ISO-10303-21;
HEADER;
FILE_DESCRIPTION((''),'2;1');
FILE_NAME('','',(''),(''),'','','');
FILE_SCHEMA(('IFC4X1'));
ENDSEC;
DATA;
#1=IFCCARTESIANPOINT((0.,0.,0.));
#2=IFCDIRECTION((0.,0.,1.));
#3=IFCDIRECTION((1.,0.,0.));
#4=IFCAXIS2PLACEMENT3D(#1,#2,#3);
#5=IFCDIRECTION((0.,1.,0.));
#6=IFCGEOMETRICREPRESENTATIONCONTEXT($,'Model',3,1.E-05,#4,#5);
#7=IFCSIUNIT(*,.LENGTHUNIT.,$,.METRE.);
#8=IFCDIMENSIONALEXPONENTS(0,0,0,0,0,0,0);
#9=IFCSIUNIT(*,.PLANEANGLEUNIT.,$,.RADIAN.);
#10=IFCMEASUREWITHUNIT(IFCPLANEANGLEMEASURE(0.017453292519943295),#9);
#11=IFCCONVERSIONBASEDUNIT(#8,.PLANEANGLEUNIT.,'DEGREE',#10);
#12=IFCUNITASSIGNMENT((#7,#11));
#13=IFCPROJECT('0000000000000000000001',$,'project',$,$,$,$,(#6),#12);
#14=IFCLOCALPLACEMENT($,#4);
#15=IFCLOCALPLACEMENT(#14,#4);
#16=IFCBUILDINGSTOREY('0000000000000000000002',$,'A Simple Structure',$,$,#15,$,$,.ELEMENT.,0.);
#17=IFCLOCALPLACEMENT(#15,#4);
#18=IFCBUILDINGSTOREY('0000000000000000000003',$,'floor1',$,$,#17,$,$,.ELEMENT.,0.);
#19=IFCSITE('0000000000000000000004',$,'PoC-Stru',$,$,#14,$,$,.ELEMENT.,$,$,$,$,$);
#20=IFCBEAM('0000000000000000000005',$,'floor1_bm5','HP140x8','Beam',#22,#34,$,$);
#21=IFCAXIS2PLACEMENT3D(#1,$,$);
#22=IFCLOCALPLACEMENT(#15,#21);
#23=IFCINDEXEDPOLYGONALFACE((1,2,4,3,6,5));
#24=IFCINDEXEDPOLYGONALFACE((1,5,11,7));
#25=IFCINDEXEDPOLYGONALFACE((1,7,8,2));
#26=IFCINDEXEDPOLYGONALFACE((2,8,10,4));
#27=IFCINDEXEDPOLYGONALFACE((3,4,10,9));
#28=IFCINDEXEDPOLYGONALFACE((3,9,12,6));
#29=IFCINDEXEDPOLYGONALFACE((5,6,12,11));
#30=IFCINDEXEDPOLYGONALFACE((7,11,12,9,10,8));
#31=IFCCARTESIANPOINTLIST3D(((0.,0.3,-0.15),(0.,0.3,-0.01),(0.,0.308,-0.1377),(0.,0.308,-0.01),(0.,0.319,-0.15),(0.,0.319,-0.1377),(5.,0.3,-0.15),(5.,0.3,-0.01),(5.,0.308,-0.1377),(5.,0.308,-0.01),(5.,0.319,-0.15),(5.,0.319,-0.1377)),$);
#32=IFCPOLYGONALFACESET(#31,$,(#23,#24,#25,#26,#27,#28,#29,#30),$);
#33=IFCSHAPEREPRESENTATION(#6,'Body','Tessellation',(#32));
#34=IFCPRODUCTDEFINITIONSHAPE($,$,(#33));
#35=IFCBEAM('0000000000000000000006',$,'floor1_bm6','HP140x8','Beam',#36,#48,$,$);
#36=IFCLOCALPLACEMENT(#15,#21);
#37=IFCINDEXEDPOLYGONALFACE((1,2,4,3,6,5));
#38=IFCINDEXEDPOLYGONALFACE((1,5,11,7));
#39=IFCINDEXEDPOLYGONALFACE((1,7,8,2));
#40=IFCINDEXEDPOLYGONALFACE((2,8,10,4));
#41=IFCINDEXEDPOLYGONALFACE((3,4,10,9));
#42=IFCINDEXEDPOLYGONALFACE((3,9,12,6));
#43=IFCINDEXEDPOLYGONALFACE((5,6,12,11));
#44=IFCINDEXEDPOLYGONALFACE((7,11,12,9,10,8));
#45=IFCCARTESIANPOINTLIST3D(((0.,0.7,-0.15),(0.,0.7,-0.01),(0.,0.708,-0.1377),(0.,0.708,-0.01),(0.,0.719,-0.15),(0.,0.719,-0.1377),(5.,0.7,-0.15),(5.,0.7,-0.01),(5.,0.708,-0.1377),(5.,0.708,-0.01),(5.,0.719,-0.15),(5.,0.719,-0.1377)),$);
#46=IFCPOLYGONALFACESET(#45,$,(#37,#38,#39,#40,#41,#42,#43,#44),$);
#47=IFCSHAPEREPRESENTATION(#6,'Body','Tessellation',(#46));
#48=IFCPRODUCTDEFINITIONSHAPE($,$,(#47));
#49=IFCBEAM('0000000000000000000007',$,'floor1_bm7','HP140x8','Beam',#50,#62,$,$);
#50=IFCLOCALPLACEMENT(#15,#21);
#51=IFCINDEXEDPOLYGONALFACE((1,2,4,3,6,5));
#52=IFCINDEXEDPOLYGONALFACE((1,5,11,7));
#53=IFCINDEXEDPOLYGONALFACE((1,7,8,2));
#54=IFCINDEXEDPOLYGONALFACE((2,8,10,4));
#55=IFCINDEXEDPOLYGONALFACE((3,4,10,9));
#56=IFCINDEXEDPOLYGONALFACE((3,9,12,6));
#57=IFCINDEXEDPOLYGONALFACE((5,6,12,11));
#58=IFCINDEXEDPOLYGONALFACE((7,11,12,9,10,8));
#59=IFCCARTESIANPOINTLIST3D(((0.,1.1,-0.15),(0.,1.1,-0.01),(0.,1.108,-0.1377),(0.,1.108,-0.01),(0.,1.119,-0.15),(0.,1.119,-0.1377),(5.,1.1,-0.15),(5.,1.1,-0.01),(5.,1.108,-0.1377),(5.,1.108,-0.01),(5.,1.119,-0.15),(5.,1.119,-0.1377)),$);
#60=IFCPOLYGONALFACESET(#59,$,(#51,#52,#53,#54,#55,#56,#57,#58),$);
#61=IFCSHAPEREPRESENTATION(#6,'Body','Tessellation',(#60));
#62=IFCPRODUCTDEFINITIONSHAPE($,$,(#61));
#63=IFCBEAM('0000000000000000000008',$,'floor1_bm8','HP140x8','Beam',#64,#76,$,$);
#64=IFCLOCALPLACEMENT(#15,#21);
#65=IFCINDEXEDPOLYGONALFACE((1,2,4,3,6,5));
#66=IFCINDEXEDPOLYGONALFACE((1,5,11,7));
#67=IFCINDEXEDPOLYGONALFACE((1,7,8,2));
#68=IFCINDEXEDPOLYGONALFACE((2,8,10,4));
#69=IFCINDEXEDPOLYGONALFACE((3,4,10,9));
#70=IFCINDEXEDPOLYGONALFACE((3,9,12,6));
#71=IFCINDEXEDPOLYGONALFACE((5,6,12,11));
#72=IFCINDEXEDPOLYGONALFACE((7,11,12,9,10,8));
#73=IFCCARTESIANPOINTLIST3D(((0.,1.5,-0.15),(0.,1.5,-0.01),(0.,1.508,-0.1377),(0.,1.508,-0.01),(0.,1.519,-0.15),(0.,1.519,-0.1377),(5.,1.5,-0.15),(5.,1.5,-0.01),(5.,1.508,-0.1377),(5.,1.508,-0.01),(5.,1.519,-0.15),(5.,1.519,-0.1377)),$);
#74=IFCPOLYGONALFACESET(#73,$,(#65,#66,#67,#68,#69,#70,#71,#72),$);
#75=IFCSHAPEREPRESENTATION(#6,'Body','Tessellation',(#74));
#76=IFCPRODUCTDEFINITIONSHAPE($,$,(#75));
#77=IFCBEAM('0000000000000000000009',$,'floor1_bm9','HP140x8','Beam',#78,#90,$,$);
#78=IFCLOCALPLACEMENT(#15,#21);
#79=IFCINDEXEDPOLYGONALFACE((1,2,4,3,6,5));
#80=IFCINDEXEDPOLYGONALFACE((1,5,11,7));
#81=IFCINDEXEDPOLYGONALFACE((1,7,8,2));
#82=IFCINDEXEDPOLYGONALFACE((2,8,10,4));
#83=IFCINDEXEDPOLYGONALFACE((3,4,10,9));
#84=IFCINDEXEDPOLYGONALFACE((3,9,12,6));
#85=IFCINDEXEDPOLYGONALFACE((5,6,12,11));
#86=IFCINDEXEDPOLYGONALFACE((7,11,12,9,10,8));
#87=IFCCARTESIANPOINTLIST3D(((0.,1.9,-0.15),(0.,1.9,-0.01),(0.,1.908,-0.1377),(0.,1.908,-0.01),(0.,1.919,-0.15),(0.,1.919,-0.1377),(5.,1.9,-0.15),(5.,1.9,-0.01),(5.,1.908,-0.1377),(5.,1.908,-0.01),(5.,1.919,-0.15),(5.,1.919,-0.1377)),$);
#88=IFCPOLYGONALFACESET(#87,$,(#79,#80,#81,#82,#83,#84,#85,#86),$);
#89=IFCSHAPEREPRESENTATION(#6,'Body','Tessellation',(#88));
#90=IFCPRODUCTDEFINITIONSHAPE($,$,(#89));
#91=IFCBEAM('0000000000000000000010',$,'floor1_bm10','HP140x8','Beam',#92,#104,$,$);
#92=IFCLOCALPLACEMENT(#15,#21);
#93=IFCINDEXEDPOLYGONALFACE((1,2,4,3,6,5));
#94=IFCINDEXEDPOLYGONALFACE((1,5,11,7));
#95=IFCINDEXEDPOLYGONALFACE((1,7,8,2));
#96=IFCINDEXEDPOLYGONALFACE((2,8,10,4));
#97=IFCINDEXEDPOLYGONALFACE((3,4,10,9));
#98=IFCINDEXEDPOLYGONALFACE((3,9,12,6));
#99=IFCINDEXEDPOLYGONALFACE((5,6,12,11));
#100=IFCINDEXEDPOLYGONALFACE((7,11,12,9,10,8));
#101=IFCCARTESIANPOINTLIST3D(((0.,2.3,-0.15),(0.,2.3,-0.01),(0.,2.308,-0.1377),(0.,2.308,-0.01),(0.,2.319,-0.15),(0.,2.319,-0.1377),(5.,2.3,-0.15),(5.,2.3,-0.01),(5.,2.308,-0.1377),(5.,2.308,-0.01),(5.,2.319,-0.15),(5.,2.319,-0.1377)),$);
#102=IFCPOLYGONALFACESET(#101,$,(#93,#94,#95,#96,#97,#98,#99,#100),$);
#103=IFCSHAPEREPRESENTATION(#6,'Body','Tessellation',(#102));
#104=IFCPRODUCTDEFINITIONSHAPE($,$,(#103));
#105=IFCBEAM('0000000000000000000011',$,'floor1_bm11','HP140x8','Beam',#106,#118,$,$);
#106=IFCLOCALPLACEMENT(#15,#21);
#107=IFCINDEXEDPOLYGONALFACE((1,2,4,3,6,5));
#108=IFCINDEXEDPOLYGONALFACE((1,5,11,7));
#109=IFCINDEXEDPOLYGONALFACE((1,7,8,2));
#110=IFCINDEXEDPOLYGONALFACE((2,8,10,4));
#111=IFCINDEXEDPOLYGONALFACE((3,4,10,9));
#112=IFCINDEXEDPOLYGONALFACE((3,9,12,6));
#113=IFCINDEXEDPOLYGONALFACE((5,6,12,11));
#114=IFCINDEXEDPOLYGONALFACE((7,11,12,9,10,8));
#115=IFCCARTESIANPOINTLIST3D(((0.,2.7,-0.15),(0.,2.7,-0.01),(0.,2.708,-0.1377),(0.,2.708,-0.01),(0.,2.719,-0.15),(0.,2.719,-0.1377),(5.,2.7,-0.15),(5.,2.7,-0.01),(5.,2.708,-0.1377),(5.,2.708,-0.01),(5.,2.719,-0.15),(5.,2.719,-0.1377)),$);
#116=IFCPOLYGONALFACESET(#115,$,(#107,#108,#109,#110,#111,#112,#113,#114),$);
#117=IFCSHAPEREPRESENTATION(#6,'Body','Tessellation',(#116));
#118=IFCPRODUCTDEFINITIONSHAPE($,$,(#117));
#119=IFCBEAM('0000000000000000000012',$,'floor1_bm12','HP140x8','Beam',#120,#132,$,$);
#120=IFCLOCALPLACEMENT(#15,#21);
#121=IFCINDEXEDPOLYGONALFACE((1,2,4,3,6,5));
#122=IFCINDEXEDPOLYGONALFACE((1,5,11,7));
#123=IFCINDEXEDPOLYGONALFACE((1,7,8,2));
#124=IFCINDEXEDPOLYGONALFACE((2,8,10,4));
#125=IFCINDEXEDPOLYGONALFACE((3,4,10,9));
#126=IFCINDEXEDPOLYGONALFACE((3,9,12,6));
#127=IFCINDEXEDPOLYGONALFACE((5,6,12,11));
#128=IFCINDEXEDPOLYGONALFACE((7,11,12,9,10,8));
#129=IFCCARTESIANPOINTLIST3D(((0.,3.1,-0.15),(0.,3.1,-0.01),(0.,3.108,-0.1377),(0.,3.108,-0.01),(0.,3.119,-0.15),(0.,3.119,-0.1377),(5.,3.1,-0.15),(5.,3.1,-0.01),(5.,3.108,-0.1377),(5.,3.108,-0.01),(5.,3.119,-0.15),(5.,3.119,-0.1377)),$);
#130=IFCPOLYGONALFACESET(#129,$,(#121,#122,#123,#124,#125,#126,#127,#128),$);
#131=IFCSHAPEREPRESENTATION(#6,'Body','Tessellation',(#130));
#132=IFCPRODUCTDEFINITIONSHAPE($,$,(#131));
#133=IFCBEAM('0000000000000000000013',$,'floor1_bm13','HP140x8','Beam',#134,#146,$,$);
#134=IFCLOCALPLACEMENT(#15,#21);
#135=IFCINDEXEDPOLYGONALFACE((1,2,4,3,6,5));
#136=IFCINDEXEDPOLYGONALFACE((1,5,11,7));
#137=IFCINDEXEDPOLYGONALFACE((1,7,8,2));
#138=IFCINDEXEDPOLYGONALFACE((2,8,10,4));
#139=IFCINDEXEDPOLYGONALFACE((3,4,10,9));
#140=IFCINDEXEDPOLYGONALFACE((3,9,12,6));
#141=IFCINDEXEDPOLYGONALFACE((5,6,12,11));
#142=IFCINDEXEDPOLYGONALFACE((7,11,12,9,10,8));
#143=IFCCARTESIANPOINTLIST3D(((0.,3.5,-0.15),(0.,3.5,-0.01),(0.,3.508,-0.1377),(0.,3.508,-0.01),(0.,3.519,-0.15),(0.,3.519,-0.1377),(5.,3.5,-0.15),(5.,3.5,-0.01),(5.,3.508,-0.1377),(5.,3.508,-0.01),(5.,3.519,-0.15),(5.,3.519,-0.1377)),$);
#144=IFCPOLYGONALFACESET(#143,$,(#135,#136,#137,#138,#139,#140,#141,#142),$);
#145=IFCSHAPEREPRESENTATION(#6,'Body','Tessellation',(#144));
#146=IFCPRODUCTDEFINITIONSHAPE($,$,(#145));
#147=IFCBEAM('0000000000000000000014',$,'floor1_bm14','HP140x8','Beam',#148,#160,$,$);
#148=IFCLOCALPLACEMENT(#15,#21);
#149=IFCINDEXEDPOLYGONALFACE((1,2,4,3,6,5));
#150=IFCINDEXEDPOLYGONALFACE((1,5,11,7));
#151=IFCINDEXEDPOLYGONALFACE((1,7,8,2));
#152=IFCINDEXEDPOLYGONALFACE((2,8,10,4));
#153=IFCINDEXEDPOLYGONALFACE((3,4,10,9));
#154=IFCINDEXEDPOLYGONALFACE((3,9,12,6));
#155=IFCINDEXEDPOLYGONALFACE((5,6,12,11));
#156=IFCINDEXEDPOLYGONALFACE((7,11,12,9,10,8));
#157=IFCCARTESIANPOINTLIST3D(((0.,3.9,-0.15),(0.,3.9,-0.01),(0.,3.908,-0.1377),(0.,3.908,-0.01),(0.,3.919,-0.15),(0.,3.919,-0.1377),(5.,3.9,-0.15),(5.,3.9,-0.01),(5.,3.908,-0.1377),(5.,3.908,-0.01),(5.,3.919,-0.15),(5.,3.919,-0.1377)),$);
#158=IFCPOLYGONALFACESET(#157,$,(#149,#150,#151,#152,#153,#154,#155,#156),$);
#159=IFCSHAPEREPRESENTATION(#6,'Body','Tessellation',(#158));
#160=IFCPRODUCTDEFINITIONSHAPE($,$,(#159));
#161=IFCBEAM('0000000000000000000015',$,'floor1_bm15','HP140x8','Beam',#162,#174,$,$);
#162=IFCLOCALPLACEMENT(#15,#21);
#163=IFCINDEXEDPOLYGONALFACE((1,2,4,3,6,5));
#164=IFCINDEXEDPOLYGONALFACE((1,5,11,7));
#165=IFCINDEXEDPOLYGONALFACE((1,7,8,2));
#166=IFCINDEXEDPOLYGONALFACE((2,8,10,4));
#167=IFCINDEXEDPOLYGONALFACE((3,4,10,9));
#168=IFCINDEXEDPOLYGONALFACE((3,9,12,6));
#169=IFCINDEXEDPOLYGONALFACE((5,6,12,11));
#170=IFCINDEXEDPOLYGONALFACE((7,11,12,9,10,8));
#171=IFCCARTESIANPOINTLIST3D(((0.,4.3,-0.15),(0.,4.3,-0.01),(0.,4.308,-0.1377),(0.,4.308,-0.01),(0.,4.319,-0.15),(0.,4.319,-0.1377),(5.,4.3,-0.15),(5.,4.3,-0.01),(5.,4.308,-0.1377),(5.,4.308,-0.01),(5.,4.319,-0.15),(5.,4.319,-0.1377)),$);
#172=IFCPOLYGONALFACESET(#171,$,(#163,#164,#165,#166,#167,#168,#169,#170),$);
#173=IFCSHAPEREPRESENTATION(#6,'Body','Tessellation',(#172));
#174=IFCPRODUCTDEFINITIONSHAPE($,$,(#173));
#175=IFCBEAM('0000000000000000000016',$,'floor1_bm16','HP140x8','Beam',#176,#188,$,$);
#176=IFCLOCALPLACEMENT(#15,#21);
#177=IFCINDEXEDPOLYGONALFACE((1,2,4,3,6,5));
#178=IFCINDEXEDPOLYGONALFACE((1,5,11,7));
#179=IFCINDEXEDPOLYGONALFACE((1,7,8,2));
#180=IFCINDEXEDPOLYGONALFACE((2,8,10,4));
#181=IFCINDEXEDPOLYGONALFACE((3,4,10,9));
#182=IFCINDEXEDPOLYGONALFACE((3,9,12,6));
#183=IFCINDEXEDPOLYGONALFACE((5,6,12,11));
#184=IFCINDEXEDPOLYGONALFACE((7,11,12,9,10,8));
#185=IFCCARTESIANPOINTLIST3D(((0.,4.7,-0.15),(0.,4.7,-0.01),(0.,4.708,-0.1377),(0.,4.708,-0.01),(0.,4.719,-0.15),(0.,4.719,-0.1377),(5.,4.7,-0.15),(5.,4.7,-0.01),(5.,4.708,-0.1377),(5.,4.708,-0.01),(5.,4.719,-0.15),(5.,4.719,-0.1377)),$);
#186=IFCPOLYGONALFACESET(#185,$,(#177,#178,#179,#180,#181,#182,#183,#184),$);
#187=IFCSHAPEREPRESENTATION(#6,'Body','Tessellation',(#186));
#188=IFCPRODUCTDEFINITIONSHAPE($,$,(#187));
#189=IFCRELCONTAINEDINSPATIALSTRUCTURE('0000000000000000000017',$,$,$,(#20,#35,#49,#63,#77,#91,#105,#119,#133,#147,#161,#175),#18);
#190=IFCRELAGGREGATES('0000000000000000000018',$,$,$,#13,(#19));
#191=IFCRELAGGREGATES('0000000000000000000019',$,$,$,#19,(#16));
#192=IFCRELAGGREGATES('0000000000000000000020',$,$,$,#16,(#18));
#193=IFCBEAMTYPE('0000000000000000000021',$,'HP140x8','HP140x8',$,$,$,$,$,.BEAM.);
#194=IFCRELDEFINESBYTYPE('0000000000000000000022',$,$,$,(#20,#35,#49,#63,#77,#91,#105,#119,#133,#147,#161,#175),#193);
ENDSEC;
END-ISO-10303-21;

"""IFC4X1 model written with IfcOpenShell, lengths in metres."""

from ifc_helpers import new_model, entity, si_unit, converted_unit, direction, frame, origin, origin_with_axes, place, context, project, spatial, polyline, outline, extrude, type_object, element, save


model = new_model("IFC4X1")

# Units and contexts
model_context = context("Model", 3, precision=1e-05, world=origin_with_axes(), true_north=direction((0.0, 1.0, 0.0)))
ifc_project = project(units=[si_unit("LENGTHUNIT", "METRE"), converted_unit("PLANEANGLEUNIT", "DEGREE", entity("IfcPlaneAngleMeasure", 0.017453292519943295), si_unit("PLANEANGLEUNIT", "RADIAN"), dimensions=[0, 0, 0, 0, 0, 0, 0])], contexts=[model_context])

# Site, storeys
site_placement = place(None, origin_with_axes())
site = spatial("IfcSite", under=ifc_project, at=site_placement, Name="PoC-Stru", CompositionType="ELEMENT")
storey_1_placement = place(site_placement, origin_with_axes())
storey_1 = spatial("IfcBuildingStorey", under=site, at=storey_1_placement, Name="A Simple Structure", CompositionType="ELEMENT", Elevation=0.0)
storey_2_placement = place(storey_1_placement, origin_with_axes())
storey_2 = spatial("IfcBuildingStorey", under=storey_1, at=storey_2_placement, Name="floor1", CompositionType="ELEMENT", Elevation=0.0)

# Beams
beam_type = type_object("IfcBeamType", Name="HP140x8", Description="HP140x8", PredefinedType="BEAM")
placement_1 = place(storey_2_placement, origin_with_axes())
beam_1_placement = place(placement_1, frame((0.0, 0.3, -0.01), z_axis=(1.0, 0.0, 0.0), x_axis=(0.0, 1.0, 0.0)))
element("IfcBeam", 1, at=beam_1_placement, inside=storey_2, type_object=beam_type, Name="floor1_bm5", Description="HP140x8", ObjectType="Beam", context=model_context, shape_type="SweptSolid", body=[
    extrude(outline(polyline([(0.0, 0.0), (0.008, 0.0), (0.008, -0.1277), (0.019, -0.1277), (0.019, -0.14), (0.0, -0.14)])), origin(), (0.0, 0.0, 1.0), 5.0),
])
placement_2 = place(storey_2_placement, origin_with_axes())
beam_2_placement = place(placement_2, frame((0.0, 0.7, -0.01), z_axis=(1.0, 0.0, 0.0), x_axis=(0.0, 1.0, 0.0)))
element("IfcBeam", 2, at=beam_2_placement, inside=storey_2, type_object=beam_type, Name="floor1_bm6", Description="HP140x8", ObjectType="Beam", context=model_context, shape_type="SweptSolid", body=[
    extrude(outline(polyline([(0.0, 0.0), (0.008, 0.0), (0.008, -0.1277), (0.019, -0.1277), (0.019, -0.14), (0.0, -0.14)])), origin(), (0.0, 0.0, 1.0), 5.0),
])
placement_3 = place(storey_2_placement, origin_with_axes())
beam_3_placement = place(placement_3, frame((0.0, 1.1, -0.01), z_axis=(1.0, 0.0, 0.0), x_axis=(0.0, 1.0, 0.0)))
element("IfcBeam", 3, at=beam_3_placement, inside=storey_2, type_object=beam_type, Name="floor1_bm7", Description="HP140x8", ObjectType="Beam", context=model_context, shape_type="SweptSolid", body=[
    extrude(outline(polyline([(0.0, 0.0), (0.008, 0.0), (0.008, -0.1277), (0.019, -0.1277), (0.019, -0.14), (0.0, -0.14)])), origin(), (0.0, 0.0, 1.0), 5.0),
])
placement_4 = place(storey_2_placement, origin_with_axes())
beam_4_placement = place(placement_4, frame((0.0, 1.5, -0.01), z_axis=(1.0, 0.0, 0.0), x_axis=(0.0, 1.0, 0.0)))
element("IfcBeam", 4, at=beam_4_placement, inside=storey_2, type_object=beam_type, Name="floor1_bm8", Description="HP140x8", ObjectType="Beam", context=model_context, shape_type="SweptSolid", body=[
    extrude(outline(polyline([(0.0, 0.0), (0.008, 0.0), (0.008, -0.1277), (0.019, -0.1277), (0.019, -0.14), (0.0, -0.14)])), origin(), (0.0, 0.0, 1.0), 5.0),
])
placement_5 = place(storey_2_placement, origin_with_axes())
beam_5_placement = place(placement_5, frame((0.0, 1.9, -0.01), z_axis=(1.0, 0.0, 0.0), x_axis=(0.0, 1.0, 0.0)))
element("IfcBeam", 5, at=beam_5_placement, inside=storey_2, type_object=beam_type, Name="floor1_bm9", Description="HP140x8", ObjectType="Beam", context=model_context, shape_type="SweptSolid", body=[
    extrude(outline(polyline([(0.0, 0.0), (0.008, 0.0), (0.008, -0.1277), (0.019, -0.1277), (0.019, -0.14), (0.0, -0.14)])), origin(), (0.0, 0.0, 1.0), 5.0),
])
placement_6 = place(storey_2_placement, origin_with_axes())
beam_6_placement = place(placement_6, frame((0.0, 2.3, -0.01), z_axis=(1.0, 0.0, 0.0), x_axis=(0.0, 1.0, 0.0)))
element("IfcBeam", 6, at=beam_6_placement, inside=storey_2, type_object=beam_type, Name="floor1_bm10", Description="HP140x8", ObjectType="Beam", context=model_context, shape_type="SweptSolid", body=[
    extrude(outline(polyline([(0.0, 0.0), (0.008, 0.0), (0.008, -0.1277), (0.019, -0.1277), (0.019, -0.14), (0.0, -0.14)])), origin(), (0.0, 0.0, 1.0), 5.0),
])
placement_7 = place(storey_2_placement, origin_with_axes())
beam_7_placement = place(placement_7, frame((0.0, 2.7, -0.01), z_axis=(1.0, 0.0, 0.0), x_axis=(0.0, 1.0, 0.0)))
element("IfcBeam", 7, at=beam_7_placement, inside=storey_2, type_object=beam_type, Name="floor1_bm11", Description="HP140x8", ObjectType="Beam", context=model_context, shape_type="SweptSolid", body=[
    extrude(outline(polyline([(0.0, 0.0), (0.008, 0.0), (0.008, -0.1277), (0.019, -0.1277), (0.019, -0.14), (0.0, -0.14)])), origin(), (0.0, 0.0, 1.0), 5.0),
])
placement_8 = place(storey_2_placement, origin_with_axes())
beam_8_placement = place(placement_8, frame((0.0, 3.1, -0.01), z_axis=(1.0, 0.0, 0.0), x_axis=(0.0, 1.0, 0.0)))
element("IfcBeam", 8, at=beam_8_placement, inside=storey_2, type_object=beam_type, Name="floor1_bm12", Description="HP140x8", ObjectType="Beam", context=model_context, shape_type="SweptSolid", body=[
    extrude(outline(polyline([(0.0, 0.0), (0.008, 0.0), (0.008, -0.1277), (0.019, -0.1277), (0.019, -0.14), (0.0, -0.14)])), origin(), (0.0, 0.0, 1.0), 5.0),
])
placement_9 = place(storey_2_placement, origin_with_axes())
beam_9_placement = place(placement_9, frame((0.0, 3.5, -0.01), z_axis=(1.0, 0.0, 0.0), x_axis=(0.0, 1.0, 0.0)))
element("IfcBeam", 9, at=beam_9_placement, inside=storey_2, type_object=beam_type, Name="floor1_bm13", Description="HP140x8", ObjectType="Beam", context=model_context, shape_type="SweptSolid", body=[
    extrude(outline(polyline([(0.0, 0.0), (0.008, 0.0), (0.008, -0.1277), (0.019, -0.1277), (0.019, -0.14), (0.0, -0.14)])), origin(), (0.0, 0.0, 1.0), 5.0),
])
placement_10 = place(storey_2_placement, origin_with_axes())
beam_10_placement = place(placement_10, frame((0.0, 3.9, -0.01), z_axis=(1.0, 0.0, 0.0), x_axis=(0.0, 1.0, 0.0)))
element("IfcBeam", 10, at=beam_10_placement, inside=storey_2, type_object=beam_type, Name="floor1_bm14", Description="HP140x8", ObjectType="Beam", context=model_context, shape_type="SweptSolid", body=[
    extrude(outline(polyline([(0.0, 0.0), (0.008, 0.0), (0.008, -0.1277), (0.019, -0.1277), (0.019, -0.14), (0.0, -0.14)])), origin(), (0.0, 0.0, 1.0), 5.0),
])
placement_11 = place(storey_2_placement, origin_with_axes())
beam_11_placement = place(placement_11, frame((0.0, 4.3, -0.01), z_axis=(1.0, 0.0, 0.0), x_axis=(0.0, 1.0, 0.0)))
element("IfcBeam", 11, at=beam_11_placement, inside=storey_2, type_object=beam_type, Name="floor1_bm15", Description="HP140x8", ObjectType="Beam", context=model_context, shape_type="SweptSolid", body=[
    extrude(outline(polyline([(0.0, 0.0), (0.008, 0.0), (0.008, -0.1277), (0.019, -0.1277), (0.019, -0.14), (0.0, -0.14)])), origin(), (0.0, 0.0, 1.0), 5.0),
])
placement_12 = place(storey_2_placement, origin_with_axes())
beam_12_placement = place(placement_12, frame((0.0, 4.7, -0.01), z_axis=(1.0, 0.0, 0.0), x_axis=(0.0, 1.0, 0.0)))
element("IfcBeam", 12, at=beam_12_placement, inside=storey_2, type_object=beam_type, Name="floor1_bm16", Description="HP140x8", ObjectType="Beam", context=model_context, shape_type="SweptSolid", body=[
    extrude(outline(polyline([(0.0, 0.0), (0.008, 0.0), (0.008, -0.1277), (0.019, -0.1277), (0.019, -0.14), (0.0, -0.14)])), origin(), (0.0, 0.0, 1.0), 5.0),
])

save(model, "model.ifc")
